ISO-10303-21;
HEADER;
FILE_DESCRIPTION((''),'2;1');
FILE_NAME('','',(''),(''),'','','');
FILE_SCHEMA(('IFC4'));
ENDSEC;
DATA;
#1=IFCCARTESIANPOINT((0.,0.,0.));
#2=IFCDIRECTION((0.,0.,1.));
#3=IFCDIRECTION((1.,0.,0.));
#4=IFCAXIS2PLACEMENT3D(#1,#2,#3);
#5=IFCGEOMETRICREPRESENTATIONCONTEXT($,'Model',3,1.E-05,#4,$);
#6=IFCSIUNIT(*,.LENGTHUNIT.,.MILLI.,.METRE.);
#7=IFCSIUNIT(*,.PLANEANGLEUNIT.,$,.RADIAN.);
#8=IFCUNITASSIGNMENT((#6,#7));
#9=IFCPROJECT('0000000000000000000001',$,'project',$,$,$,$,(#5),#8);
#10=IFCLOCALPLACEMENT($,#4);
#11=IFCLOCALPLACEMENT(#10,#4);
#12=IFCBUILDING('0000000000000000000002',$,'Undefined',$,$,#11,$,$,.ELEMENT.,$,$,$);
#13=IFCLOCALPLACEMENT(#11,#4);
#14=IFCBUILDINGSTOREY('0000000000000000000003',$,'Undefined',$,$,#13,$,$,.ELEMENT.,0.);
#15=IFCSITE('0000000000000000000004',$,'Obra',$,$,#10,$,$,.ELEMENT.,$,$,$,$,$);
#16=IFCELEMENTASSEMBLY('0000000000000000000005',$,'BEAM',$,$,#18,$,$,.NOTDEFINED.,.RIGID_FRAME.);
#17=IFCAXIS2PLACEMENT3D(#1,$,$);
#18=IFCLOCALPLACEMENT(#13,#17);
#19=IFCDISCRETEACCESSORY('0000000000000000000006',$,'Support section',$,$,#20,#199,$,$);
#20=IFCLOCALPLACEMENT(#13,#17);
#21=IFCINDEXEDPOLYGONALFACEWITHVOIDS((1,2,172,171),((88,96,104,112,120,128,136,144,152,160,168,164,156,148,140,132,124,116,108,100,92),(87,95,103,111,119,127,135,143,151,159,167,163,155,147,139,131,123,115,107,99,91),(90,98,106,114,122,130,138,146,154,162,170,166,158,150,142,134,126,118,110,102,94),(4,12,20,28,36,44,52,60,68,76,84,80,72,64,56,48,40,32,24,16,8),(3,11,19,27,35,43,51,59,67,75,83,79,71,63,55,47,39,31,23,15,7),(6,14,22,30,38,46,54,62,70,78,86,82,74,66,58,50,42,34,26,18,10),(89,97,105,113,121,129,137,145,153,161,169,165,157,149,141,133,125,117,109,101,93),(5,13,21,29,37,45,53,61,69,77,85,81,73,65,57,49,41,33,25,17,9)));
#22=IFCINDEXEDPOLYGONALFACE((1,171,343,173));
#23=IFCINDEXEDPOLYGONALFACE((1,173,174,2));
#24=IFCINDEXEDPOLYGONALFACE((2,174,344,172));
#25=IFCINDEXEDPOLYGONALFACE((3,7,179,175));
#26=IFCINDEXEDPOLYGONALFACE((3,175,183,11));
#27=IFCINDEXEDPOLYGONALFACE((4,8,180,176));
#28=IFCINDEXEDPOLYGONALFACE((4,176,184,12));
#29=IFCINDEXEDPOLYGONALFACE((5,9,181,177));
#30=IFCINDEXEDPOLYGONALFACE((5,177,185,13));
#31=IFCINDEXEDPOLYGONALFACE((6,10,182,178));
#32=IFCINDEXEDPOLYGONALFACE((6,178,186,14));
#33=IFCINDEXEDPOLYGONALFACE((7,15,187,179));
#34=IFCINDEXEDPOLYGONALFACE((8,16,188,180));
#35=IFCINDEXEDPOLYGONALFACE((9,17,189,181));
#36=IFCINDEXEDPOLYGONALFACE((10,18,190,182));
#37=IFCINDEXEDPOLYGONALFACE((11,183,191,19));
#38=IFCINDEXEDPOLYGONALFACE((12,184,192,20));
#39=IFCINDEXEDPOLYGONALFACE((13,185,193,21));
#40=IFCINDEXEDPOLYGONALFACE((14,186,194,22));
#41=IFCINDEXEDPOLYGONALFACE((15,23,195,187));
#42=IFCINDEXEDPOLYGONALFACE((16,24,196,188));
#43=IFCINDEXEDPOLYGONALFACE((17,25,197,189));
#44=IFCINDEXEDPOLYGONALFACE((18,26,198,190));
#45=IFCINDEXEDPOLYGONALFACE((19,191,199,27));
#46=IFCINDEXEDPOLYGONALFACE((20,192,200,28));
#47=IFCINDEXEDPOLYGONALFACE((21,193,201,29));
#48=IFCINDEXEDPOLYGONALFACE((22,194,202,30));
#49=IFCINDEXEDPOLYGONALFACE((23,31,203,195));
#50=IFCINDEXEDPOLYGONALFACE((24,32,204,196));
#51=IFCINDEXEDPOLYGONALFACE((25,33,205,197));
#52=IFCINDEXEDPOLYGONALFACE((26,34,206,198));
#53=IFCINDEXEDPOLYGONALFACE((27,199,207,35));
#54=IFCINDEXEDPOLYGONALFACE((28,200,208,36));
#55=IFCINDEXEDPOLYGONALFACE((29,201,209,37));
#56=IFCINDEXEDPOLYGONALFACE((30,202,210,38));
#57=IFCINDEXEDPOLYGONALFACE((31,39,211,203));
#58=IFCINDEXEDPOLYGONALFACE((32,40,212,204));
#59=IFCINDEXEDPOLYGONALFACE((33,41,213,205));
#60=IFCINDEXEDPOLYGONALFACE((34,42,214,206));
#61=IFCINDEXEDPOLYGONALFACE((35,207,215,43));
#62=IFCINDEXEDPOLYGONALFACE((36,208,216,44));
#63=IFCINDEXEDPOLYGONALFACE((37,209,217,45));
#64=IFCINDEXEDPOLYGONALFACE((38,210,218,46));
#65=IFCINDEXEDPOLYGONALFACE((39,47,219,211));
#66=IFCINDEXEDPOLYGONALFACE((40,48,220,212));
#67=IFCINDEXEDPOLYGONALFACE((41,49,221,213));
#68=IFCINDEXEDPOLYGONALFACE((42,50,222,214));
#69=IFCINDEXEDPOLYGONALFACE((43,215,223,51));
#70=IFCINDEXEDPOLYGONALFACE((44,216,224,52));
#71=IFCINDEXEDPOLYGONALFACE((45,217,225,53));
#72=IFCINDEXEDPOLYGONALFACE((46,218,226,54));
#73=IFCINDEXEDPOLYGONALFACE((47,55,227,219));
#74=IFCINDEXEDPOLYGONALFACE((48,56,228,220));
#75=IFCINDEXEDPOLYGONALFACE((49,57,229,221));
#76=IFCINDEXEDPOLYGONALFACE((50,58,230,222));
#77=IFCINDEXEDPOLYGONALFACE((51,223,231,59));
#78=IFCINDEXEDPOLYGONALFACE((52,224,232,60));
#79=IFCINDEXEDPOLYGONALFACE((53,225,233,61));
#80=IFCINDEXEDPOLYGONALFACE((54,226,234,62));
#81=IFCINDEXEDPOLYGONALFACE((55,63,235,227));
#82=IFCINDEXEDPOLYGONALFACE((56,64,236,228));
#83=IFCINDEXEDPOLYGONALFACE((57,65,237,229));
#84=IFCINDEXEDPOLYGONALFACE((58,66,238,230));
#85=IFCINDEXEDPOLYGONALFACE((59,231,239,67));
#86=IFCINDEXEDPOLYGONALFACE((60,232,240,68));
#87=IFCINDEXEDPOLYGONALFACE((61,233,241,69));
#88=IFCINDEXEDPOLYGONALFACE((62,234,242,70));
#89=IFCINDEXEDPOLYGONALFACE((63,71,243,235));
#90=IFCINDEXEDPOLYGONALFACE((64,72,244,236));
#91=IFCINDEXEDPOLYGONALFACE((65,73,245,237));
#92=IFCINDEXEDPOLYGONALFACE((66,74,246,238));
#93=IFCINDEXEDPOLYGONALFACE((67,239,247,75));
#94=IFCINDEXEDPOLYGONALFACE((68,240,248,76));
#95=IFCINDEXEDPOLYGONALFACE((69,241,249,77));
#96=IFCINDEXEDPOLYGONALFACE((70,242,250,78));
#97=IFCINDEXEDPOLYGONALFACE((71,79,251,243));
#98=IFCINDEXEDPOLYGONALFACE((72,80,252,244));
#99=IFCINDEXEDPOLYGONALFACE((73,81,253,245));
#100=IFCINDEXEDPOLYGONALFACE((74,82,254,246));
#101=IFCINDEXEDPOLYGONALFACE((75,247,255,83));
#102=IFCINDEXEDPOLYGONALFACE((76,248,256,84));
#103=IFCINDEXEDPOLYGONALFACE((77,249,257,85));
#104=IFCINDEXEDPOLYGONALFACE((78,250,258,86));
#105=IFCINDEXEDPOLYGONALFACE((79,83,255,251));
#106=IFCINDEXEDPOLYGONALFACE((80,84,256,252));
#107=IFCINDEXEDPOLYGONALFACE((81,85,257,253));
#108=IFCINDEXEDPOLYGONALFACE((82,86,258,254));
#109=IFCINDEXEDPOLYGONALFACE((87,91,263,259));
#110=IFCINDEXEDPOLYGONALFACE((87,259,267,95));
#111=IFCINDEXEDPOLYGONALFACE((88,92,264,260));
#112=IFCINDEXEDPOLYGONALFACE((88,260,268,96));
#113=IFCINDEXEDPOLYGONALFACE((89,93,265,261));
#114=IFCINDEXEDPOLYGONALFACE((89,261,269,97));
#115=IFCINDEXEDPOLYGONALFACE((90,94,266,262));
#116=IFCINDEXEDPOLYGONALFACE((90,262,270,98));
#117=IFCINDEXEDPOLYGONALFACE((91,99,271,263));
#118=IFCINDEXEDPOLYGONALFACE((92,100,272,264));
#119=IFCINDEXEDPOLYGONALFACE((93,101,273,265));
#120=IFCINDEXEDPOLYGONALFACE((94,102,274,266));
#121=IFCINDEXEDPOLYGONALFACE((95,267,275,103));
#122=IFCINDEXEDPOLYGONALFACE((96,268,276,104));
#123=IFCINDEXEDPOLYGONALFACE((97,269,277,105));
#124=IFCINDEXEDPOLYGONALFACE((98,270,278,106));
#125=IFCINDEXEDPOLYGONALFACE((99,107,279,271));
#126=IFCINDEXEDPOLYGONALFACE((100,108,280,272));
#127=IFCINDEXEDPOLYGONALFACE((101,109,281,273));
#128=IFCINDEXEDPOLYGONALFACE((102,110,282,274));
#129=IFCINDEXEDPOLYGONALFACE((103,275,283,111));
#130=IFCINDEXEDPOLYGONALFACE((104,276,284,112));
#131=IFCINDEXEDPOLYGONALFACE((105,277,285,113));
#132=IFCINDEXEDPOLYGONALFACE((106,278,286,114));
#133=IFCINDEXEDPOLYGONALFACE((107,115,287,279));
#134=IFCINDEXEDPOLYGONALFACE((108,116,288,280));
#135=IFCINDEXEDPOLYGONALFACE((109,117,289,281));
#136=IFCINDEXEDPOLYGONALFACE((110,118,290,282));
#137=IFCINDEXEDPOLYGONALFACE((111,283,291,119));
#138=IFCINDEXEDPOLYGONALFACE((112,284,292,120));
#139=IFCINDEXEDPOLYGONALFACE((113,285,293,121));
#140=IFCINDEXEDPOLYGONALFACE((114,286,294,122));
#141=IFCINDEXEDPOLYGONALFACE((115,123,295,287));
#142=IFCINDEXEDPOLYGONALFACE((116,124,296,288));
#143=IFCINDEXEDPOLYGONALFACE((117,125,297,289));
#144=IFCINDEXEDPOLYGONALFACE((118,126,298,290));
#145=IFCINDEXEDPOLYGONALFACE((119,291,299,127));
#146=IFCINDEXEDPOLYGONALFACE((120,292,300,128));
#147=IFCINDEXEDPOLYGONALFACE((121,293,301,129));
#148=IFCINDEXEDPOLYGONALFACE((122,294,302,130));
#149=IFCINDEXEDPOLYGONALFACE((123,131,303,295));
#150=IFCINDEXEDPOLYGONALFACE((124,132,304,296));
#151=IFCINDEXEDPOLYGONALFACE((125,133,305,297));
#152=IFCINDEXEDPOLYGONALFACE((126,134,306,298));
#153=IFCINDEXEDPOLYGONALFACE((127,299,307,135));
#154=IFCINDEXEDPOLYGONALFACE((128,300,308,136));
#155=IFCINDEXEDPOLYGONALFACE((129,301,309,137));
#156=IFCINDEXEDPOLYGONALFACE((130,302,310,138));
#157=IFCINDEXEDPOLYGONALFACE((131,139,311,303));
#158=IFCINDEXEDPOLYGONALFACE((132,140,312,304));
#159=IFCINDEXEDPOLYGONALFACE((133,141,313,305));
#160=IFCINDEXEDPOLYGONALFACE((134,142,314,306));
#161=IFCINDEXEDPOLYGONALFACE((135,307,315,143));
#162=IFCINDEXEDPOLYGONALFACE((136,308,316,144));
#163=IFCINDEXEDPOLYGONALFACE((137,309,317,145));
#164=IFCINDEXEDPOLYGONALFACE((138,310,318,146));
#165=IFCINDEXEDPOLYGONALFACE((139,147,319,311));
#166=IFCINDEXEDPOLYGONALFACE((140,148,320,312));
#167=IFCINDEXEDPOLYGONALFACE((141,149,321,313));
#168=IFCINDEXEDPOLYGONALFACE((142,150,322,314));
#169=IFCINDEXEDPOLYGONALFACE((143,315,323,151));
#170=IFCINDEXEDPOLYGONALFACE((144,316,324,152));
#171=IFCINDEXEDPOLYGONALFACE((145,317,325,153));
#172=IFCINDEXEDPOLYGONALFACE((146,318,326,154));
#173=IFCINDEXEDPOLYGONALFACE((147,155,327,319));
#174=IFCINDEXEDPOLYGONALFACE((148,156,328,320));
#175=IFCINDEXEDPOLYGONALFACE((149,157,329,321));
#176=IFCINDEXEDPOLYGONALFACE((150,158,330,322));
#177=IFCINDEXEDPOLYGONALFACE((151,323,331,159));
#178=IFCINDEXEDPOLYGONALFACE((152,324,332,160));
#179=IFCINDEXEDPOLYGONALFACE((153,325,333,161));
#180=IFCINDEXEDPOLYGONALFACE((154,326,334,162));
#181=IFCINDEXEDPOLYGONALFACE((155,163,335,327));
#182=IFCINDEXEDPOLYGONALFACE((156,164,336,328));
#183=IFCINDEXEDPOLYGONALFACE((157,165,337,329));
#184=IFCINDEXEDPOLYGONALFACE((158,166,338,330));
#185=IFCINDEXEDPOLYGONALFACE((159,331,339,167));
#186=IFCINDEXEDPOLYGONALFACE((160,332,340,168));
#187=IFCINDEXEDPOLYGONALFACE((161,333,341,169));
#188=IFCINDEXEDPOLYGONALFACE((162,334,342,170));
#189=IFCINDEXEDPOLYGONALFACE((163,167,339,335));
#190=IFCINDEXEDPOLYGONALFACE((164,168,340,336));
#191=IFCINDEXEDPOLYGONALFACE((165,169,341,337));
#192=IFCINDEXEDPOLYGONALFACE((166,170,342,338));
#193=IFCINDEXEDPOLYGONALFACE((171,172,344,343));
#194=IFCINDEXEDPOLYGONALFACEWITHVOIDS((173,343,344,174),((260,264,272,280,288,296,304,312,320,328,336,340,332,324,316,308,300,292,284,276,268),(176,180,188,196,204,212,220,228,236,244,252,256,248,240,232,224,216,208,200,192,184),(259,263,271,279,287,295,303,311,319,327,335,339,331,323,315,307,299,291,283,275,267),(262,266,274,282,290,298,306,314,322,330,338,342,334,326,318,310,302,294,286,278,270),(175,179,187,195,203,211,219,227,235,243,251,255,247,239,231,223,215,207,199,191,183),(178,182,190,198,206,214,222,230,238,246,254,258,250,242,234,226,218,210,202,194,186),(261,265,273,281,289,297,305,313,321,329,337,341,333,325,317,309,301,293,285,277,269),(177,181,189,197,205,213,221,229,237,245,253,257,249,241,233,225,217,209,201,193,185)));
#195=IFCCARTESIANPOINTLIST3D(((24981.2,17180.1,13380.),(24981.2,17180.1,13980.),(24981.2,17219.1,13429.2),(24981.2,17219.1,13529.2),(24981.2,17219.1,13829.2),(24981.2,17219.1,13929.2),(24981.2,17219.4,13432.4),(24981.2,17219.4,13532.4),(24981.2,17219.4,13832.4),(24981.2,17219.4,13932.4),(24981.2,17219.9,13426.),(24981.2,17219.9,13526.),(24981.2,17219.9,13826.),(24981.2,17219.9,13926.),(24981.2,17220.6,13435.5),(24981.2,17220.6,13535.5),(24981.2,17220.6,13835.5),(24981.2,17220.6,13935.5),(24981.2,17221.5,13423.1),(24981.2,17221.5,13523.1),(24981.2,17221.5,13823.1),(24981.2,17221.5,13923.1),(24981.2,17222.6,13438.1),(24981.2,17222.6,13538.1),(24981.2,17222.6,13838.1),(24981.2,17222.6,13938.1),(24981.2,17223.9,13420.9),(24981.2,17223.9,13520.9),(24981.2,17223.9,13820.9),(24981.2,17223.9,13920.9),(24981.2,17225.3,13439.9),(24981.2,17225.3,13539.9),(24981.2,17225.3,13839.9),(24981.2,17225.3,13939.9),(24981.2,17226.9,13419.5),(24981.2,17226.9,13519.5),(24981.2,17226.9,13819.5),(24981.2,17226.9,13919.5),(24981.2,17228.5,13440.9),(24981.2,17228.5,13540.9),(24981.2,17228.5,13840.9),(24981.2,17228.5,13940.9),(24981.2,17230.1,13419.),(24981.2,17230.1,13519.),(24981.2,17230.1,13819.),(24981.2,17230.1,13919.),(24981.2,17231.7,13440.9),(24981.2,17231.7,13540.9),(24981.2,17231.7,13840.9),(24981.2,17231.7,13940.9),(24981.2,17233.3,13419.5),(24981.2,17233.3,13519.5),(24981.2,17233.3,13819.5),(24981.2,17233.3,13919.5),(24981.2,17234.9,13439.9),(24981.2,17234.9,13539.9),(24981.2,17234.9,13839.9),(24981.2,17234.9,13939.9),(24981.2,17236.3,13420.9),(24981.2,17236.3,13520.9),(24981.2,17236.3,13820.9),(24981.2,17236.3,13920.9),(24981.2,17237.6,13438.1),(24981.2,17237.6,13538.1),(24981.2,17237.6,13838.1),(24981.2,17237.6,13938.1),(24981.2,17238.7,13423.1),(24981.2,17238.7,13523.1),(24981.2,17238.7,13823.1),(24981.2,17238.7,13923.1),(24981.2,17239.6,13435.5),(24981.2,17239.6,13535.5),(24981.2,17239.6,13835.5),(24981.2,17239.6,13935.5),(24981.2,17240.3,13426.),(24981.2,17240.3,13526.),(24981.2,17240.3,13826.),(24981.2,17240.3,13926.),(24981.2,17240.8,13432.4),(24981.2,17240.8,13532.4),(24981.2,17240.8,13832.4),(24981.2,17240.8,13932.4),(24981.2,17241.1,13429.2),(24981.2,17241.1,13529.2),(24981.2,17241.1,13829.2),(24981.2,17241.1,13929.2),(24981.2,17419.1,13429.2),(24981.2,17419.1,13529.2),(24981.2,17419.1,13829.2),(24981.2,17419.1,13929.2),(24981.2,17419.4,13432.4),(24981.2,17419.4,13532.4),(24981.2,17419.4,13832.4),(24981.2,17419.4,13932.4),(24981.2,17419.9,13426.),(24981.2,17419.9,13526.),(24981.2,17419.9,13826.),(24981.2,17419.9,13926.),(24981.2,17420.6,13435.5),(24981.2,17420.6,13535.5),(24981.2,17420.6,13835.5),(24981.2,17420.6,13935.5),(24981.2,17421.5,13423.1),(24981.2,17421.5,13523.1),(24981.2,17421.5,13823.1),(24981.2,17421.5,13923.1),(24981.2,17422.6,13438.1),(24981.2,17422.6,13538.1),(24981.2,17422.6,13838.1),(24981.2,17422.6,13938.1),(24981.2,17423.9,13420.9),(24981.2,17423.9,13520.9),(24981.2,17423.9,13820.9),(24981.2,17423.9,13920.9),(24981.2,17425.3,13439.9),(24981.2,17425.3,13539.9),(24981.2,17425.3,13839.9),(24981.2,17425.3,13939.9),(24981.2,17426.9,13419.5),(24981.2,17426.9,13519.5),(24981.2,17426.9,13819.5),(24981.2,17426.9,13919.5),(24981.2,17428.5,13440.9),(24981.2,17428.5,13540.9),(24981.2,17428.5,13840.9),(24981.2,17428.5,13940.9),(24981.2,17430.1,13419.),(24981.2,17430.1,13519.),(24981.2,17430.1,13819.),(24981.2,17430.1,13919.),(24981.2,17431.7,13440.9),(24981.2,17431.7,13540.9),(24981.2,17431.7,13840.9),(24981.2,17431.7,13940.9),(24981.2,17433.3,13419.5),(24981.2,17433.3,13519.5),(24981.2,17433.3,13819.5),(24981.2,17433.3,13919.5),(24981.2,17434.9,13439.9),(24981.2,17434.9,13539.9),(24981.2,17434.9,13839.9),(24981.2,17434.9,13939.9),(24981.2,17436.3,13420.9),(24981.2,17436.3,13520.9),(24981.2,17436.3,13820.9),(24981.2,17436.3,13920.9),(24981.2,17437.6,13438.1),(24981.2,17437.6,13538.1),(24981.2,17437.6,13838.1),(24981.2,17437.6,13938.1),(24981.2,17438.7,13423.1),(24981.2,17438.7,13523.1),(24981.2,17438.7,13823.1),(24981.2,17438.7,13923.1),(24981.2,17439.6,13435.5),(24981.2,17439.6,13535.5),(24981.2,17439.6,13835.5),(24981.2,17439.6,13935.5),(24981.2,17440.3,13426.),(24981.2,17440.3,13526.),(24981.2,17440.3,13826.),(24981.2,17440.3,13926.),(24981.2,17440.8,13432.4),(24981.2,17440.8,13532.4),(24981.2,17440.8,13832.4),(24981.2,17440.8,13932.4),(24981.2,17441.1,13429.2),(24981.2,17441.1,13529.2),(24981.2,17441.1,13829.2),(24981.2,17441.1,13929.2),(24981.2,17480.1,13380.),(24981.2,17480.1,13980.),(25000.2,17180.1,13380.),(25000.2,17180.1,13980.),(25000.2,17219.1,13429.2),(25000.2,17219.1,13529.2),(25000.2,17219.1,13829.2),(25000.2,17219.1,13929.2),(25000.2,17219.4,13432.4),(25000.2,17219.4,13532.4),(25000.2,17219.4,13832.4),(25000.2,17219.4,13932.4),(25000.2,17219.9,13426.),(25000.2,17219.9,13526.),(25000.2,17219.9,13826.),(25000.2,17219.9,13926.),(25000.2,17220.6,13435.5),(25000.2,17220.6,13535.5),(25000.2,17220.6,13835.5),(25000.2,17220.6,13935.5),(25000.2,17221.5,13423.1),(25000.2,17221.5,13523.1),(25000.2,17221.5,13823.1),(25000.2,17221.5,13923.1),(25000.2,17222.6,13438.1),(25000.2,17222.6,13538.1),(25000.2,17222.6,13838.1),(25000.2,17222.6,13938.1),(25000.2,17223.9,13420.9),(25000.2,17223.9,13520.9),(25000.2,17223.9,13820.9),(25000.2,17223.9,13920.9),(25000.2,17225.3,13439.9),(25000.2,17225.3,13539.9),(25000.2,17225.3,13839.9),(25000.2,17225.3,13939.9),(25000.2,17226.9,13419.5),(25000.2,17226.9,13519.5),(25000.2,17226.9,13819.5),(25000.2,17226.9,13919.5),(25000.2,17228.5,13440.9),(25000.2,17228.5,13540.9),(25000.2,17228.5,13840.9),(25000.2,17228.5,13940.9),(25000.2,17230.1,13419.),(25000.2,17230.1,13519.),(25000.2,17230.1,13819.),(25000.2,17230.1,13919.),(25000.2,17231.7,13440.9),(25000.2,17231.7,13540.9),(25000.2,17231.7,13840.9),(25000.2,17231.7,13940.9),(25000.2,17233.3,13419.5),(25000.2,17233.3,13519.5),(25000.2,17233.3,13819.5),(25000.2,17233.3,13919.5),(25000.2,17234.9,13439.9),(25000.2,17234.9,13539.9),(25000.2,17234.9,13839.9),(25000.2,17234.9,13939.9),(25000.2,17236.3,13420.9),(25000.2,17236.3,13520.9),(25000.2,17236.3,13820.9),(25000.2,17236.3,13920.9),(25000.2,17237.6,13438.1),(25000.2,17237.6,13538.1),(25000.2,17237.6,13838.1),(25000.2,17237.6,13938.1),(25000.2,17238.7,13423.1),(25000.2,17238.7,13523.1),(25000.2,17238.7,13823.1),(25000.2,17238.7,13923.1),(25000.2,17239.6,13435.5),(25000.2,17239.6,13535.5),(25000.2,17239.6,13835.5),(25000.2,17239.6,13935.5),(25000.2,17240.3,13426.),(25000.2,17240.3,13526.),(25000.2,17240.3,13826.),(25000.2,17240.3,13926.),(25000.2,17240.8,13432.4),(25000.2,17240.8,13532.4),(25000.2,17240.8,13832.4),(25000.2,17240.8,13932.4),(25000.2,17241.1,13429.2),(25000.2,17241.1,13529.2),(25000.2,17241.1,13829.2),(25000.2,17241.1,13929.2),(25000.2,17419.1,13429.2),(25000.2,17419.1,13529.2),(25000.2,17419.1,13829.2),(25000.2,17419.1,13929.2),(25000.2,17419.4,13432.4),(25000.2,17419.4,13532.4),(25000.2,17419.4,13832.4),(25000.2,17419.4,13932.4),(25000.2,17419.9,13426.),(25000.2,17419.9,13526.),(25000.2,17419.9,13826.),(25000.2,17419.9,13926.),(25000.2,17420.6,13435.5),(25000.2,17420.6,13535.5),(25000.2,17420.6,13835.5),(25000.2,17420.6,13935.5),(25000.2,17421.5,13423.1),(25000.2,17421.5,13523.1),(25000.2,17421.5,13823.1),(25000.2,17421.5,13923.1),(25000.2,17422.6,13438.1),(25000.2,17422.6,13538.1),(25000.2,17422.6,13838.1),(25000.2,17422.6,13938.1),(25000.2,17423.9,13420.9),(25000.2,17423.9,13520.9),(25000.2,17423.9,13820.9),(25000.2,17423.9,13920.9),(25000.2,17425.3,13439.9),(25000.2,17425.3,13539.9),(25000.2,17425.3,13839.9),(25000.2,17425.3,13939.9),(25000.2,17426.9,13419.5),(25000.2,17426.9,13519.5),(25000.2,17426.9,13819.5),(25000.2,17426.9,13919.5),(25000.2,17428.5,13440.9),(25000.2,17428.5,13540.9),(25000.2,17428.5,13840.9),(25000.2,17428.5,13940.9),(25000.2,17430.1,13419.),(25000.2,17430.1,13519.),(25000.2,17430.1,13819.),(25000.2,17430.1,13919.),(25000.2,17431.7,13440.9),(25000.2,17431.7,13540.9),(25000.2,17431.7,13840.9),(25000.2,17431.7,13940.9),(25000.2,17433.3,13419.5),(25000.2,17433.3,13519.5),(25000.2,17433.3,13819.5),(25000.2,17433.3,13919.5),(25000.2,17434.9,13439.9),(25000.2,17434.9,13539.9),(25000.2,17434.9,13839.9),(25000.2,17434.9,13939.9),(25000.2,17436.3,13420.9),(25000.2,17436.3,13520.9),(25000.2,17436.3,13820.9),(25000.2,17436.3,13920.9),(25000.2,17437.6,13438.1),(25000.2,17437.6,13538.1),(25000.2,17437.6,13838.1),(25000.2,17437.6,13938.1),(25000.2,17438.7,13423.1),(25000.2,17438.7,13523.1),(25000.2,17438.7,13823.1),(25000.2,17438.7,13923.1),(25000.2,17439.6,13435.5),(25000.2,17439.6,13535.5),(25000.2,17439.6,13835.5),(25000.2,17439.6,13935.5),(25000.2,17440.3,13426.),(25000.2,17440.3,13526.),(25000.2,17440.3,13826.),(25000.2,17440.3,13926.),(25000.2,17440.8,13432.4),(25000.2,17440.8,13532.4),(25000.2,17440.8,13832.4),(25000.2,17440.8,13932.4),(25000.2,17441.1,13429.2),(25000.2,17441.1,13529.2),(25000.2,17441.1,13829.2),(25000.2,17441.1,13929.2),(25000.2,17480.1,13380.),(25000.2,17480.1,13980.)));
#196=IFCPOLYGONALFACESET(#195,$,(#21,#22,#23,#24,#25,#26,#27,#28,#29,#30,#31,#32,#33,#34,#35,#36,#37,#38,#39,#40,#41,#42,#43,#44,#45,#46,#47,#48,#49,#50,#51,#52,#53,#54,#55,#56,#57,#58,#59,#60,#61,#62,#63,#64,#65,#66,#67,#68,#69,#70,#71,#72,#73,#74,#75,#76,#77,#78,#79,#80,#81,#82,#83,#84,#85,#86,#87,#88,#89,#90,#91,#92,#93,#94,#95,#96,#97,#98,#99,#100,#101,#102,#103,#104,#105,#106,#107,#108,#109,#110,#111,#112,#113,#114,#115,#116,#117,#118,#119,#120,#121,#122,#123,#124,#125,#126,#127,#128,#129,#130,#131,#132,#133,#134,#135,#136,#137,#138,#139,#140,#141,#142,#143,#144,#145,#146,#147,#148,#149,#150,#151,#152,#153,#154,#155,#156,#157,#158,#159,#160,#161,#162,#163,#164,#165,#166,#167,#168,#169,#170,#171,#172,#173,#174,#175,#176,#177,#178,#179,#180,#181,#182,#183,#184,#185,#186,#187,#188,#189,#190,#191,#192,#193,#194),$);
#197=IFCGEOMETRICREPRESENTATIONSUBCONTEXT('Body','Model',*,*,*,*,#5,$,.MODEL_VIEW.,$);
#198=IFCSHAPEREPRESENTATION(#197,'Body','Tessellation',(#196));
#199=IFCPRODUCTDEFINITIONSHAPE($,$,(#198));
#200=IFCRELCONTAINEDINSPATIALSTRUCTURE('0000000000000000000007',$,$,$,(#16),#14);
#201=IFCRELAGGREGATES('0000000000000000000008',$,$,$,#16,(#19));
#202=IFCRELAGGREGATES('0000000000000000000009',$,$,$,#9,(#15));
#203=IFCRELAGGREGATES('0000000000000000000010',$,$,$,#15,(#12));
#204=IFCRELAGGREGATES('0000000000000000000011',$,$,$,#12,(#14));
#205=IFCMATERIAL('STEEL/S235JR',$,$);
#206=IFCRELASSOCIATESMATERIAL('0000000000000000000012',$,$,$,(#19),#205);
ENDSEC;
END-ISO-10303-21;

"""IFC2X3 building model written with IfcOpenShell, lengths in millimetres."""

from ifc_helpers import new_model, si_unit, frame, origin_with_axes, origin_2d_with_axis, place, context, subcontext, project, spatial, rectangle, circle, extrude, source, transform, mapped, material, element, aggregate, save


model = new_model("IFC2X3")

# Units and contexts
model_context = context("Model", 3, precision=1e-05, world=origin_with_axes())
body_context = subcontext(model_context, "Body", "Model", "MODEL_VIEW")
ifc_project = project(units=[si_unit("LENGTHUNIT", "METRE", prefix="MILLI"), si_unit("PLANEANGLEUNIT", "RADIAN")], contexts=[model_context])

# Site, building, storey
site_placement = place(None, origin_with_axes())
site = spatial("IfcSite", under=ifc_project, at=site_placement, Name="Obra", CompositionType="ELEMENT")
building_placement = place(site_placement, origin_with_axes())
building = spatial("IfcBuilding", under=site, at=building_placement, Name="Undefined", CompositionType="ELEMENT")
storey_placement = place(building_placement, origin_with_axes())
storey = spatial("IfcBuildingStorey", under=building, at=storey_placement, Name="Undefined", CompositionType="ELEMENT", Elevation=0.0)

# Shared definitions
ifc_material_1 = material(Name="STEEL/S235JR")

# Element assembly, discrete accessory, opening
assembly_1_placement = place(storey_placement, origin_with_axes())
assembly_1 = element("IfcElementAssembly", 1, at=assembly_1_placement, inside=storey, Name="BEAM", AssemblyPlace="NOTDEFINED", PredefinedType="RIGID_FRAME")
discrete_accessory_1_placement = place(assembly_1_placement, frame((24990.7, 17330.1, 13380.0), z_axis=(0.0, 0.0, 1.0), x_axis=(-0.000129, -1.0, 0.0)))
discrete_accessory_1 = element("IfcDiscreteAccessory", 2, at=discrete_accessory_1_placement, material=ifc_material_1, Name="Support section", context=body_context, shape_type="SweptSolid", body=[
    extrude(rectangle(XDim=19.0, YDim=300.0, at=origin_2d_with_axis()), frame((0.0, 0.0, 600.0), z_axis=(0.0, 0.0, -1.0), x_axis=(0.0, 1.0, 0.0)), (0.0, 0.0, 1.0), 600.0),
])
shared_shape_1 = source(origin_with_axes(), body_context, "Body", "SweptSolid", [
    extrude(circle(Radius=11.0, at=origin_2d_with_axis()), frame((0.0, -19.1, 0.0), z_axis=(0.0, 1.0, 0.0), x_axis=(1.0, 0.0, 0.0)), (0.0, 0.0, 1.0), 19.2),
])
opening_1_placement = place(assembly_1_placement, frame((25000.2, 17330.1, 13900.0), z_axis=(-0.000129, -1.0, 0.0), x_axis=(0.0, 0.0, -1.0)))
element("IfcOpeningElement", 3, at=opening_1_placement, cuts=discrete_accessory_1, ObjectType="Opening", context=body_context, shape_type="MappedRepresentation", body=[
    mapped(shared_shape_1, transform((-30.0, 0.0, -100.0))),
    mapped(shared_shape_1, transform((-30.0, 0.0, 100.0))),
    mapped(shared_shape_1, transform((70.0, 0.0, -100.0))),
    mapped(shared_shape_1, transform((70.0, 0.0, 100.0))),
    mapped(shared_shape_1, transform((370.0, 0.0, -100.0))),
    mapped(shared_shape_1, transform((370.0, 0.0, 100.0))),
    mapped(shared_shape_1, transform((470.0, 0.0, -100.0))),
    mapped(shared_shape_1, transform((470.0, 0.0, 100.0))),
])

aggregate(assembly_1, [discrete_accessory_1])

save(model, "model.ifc")
